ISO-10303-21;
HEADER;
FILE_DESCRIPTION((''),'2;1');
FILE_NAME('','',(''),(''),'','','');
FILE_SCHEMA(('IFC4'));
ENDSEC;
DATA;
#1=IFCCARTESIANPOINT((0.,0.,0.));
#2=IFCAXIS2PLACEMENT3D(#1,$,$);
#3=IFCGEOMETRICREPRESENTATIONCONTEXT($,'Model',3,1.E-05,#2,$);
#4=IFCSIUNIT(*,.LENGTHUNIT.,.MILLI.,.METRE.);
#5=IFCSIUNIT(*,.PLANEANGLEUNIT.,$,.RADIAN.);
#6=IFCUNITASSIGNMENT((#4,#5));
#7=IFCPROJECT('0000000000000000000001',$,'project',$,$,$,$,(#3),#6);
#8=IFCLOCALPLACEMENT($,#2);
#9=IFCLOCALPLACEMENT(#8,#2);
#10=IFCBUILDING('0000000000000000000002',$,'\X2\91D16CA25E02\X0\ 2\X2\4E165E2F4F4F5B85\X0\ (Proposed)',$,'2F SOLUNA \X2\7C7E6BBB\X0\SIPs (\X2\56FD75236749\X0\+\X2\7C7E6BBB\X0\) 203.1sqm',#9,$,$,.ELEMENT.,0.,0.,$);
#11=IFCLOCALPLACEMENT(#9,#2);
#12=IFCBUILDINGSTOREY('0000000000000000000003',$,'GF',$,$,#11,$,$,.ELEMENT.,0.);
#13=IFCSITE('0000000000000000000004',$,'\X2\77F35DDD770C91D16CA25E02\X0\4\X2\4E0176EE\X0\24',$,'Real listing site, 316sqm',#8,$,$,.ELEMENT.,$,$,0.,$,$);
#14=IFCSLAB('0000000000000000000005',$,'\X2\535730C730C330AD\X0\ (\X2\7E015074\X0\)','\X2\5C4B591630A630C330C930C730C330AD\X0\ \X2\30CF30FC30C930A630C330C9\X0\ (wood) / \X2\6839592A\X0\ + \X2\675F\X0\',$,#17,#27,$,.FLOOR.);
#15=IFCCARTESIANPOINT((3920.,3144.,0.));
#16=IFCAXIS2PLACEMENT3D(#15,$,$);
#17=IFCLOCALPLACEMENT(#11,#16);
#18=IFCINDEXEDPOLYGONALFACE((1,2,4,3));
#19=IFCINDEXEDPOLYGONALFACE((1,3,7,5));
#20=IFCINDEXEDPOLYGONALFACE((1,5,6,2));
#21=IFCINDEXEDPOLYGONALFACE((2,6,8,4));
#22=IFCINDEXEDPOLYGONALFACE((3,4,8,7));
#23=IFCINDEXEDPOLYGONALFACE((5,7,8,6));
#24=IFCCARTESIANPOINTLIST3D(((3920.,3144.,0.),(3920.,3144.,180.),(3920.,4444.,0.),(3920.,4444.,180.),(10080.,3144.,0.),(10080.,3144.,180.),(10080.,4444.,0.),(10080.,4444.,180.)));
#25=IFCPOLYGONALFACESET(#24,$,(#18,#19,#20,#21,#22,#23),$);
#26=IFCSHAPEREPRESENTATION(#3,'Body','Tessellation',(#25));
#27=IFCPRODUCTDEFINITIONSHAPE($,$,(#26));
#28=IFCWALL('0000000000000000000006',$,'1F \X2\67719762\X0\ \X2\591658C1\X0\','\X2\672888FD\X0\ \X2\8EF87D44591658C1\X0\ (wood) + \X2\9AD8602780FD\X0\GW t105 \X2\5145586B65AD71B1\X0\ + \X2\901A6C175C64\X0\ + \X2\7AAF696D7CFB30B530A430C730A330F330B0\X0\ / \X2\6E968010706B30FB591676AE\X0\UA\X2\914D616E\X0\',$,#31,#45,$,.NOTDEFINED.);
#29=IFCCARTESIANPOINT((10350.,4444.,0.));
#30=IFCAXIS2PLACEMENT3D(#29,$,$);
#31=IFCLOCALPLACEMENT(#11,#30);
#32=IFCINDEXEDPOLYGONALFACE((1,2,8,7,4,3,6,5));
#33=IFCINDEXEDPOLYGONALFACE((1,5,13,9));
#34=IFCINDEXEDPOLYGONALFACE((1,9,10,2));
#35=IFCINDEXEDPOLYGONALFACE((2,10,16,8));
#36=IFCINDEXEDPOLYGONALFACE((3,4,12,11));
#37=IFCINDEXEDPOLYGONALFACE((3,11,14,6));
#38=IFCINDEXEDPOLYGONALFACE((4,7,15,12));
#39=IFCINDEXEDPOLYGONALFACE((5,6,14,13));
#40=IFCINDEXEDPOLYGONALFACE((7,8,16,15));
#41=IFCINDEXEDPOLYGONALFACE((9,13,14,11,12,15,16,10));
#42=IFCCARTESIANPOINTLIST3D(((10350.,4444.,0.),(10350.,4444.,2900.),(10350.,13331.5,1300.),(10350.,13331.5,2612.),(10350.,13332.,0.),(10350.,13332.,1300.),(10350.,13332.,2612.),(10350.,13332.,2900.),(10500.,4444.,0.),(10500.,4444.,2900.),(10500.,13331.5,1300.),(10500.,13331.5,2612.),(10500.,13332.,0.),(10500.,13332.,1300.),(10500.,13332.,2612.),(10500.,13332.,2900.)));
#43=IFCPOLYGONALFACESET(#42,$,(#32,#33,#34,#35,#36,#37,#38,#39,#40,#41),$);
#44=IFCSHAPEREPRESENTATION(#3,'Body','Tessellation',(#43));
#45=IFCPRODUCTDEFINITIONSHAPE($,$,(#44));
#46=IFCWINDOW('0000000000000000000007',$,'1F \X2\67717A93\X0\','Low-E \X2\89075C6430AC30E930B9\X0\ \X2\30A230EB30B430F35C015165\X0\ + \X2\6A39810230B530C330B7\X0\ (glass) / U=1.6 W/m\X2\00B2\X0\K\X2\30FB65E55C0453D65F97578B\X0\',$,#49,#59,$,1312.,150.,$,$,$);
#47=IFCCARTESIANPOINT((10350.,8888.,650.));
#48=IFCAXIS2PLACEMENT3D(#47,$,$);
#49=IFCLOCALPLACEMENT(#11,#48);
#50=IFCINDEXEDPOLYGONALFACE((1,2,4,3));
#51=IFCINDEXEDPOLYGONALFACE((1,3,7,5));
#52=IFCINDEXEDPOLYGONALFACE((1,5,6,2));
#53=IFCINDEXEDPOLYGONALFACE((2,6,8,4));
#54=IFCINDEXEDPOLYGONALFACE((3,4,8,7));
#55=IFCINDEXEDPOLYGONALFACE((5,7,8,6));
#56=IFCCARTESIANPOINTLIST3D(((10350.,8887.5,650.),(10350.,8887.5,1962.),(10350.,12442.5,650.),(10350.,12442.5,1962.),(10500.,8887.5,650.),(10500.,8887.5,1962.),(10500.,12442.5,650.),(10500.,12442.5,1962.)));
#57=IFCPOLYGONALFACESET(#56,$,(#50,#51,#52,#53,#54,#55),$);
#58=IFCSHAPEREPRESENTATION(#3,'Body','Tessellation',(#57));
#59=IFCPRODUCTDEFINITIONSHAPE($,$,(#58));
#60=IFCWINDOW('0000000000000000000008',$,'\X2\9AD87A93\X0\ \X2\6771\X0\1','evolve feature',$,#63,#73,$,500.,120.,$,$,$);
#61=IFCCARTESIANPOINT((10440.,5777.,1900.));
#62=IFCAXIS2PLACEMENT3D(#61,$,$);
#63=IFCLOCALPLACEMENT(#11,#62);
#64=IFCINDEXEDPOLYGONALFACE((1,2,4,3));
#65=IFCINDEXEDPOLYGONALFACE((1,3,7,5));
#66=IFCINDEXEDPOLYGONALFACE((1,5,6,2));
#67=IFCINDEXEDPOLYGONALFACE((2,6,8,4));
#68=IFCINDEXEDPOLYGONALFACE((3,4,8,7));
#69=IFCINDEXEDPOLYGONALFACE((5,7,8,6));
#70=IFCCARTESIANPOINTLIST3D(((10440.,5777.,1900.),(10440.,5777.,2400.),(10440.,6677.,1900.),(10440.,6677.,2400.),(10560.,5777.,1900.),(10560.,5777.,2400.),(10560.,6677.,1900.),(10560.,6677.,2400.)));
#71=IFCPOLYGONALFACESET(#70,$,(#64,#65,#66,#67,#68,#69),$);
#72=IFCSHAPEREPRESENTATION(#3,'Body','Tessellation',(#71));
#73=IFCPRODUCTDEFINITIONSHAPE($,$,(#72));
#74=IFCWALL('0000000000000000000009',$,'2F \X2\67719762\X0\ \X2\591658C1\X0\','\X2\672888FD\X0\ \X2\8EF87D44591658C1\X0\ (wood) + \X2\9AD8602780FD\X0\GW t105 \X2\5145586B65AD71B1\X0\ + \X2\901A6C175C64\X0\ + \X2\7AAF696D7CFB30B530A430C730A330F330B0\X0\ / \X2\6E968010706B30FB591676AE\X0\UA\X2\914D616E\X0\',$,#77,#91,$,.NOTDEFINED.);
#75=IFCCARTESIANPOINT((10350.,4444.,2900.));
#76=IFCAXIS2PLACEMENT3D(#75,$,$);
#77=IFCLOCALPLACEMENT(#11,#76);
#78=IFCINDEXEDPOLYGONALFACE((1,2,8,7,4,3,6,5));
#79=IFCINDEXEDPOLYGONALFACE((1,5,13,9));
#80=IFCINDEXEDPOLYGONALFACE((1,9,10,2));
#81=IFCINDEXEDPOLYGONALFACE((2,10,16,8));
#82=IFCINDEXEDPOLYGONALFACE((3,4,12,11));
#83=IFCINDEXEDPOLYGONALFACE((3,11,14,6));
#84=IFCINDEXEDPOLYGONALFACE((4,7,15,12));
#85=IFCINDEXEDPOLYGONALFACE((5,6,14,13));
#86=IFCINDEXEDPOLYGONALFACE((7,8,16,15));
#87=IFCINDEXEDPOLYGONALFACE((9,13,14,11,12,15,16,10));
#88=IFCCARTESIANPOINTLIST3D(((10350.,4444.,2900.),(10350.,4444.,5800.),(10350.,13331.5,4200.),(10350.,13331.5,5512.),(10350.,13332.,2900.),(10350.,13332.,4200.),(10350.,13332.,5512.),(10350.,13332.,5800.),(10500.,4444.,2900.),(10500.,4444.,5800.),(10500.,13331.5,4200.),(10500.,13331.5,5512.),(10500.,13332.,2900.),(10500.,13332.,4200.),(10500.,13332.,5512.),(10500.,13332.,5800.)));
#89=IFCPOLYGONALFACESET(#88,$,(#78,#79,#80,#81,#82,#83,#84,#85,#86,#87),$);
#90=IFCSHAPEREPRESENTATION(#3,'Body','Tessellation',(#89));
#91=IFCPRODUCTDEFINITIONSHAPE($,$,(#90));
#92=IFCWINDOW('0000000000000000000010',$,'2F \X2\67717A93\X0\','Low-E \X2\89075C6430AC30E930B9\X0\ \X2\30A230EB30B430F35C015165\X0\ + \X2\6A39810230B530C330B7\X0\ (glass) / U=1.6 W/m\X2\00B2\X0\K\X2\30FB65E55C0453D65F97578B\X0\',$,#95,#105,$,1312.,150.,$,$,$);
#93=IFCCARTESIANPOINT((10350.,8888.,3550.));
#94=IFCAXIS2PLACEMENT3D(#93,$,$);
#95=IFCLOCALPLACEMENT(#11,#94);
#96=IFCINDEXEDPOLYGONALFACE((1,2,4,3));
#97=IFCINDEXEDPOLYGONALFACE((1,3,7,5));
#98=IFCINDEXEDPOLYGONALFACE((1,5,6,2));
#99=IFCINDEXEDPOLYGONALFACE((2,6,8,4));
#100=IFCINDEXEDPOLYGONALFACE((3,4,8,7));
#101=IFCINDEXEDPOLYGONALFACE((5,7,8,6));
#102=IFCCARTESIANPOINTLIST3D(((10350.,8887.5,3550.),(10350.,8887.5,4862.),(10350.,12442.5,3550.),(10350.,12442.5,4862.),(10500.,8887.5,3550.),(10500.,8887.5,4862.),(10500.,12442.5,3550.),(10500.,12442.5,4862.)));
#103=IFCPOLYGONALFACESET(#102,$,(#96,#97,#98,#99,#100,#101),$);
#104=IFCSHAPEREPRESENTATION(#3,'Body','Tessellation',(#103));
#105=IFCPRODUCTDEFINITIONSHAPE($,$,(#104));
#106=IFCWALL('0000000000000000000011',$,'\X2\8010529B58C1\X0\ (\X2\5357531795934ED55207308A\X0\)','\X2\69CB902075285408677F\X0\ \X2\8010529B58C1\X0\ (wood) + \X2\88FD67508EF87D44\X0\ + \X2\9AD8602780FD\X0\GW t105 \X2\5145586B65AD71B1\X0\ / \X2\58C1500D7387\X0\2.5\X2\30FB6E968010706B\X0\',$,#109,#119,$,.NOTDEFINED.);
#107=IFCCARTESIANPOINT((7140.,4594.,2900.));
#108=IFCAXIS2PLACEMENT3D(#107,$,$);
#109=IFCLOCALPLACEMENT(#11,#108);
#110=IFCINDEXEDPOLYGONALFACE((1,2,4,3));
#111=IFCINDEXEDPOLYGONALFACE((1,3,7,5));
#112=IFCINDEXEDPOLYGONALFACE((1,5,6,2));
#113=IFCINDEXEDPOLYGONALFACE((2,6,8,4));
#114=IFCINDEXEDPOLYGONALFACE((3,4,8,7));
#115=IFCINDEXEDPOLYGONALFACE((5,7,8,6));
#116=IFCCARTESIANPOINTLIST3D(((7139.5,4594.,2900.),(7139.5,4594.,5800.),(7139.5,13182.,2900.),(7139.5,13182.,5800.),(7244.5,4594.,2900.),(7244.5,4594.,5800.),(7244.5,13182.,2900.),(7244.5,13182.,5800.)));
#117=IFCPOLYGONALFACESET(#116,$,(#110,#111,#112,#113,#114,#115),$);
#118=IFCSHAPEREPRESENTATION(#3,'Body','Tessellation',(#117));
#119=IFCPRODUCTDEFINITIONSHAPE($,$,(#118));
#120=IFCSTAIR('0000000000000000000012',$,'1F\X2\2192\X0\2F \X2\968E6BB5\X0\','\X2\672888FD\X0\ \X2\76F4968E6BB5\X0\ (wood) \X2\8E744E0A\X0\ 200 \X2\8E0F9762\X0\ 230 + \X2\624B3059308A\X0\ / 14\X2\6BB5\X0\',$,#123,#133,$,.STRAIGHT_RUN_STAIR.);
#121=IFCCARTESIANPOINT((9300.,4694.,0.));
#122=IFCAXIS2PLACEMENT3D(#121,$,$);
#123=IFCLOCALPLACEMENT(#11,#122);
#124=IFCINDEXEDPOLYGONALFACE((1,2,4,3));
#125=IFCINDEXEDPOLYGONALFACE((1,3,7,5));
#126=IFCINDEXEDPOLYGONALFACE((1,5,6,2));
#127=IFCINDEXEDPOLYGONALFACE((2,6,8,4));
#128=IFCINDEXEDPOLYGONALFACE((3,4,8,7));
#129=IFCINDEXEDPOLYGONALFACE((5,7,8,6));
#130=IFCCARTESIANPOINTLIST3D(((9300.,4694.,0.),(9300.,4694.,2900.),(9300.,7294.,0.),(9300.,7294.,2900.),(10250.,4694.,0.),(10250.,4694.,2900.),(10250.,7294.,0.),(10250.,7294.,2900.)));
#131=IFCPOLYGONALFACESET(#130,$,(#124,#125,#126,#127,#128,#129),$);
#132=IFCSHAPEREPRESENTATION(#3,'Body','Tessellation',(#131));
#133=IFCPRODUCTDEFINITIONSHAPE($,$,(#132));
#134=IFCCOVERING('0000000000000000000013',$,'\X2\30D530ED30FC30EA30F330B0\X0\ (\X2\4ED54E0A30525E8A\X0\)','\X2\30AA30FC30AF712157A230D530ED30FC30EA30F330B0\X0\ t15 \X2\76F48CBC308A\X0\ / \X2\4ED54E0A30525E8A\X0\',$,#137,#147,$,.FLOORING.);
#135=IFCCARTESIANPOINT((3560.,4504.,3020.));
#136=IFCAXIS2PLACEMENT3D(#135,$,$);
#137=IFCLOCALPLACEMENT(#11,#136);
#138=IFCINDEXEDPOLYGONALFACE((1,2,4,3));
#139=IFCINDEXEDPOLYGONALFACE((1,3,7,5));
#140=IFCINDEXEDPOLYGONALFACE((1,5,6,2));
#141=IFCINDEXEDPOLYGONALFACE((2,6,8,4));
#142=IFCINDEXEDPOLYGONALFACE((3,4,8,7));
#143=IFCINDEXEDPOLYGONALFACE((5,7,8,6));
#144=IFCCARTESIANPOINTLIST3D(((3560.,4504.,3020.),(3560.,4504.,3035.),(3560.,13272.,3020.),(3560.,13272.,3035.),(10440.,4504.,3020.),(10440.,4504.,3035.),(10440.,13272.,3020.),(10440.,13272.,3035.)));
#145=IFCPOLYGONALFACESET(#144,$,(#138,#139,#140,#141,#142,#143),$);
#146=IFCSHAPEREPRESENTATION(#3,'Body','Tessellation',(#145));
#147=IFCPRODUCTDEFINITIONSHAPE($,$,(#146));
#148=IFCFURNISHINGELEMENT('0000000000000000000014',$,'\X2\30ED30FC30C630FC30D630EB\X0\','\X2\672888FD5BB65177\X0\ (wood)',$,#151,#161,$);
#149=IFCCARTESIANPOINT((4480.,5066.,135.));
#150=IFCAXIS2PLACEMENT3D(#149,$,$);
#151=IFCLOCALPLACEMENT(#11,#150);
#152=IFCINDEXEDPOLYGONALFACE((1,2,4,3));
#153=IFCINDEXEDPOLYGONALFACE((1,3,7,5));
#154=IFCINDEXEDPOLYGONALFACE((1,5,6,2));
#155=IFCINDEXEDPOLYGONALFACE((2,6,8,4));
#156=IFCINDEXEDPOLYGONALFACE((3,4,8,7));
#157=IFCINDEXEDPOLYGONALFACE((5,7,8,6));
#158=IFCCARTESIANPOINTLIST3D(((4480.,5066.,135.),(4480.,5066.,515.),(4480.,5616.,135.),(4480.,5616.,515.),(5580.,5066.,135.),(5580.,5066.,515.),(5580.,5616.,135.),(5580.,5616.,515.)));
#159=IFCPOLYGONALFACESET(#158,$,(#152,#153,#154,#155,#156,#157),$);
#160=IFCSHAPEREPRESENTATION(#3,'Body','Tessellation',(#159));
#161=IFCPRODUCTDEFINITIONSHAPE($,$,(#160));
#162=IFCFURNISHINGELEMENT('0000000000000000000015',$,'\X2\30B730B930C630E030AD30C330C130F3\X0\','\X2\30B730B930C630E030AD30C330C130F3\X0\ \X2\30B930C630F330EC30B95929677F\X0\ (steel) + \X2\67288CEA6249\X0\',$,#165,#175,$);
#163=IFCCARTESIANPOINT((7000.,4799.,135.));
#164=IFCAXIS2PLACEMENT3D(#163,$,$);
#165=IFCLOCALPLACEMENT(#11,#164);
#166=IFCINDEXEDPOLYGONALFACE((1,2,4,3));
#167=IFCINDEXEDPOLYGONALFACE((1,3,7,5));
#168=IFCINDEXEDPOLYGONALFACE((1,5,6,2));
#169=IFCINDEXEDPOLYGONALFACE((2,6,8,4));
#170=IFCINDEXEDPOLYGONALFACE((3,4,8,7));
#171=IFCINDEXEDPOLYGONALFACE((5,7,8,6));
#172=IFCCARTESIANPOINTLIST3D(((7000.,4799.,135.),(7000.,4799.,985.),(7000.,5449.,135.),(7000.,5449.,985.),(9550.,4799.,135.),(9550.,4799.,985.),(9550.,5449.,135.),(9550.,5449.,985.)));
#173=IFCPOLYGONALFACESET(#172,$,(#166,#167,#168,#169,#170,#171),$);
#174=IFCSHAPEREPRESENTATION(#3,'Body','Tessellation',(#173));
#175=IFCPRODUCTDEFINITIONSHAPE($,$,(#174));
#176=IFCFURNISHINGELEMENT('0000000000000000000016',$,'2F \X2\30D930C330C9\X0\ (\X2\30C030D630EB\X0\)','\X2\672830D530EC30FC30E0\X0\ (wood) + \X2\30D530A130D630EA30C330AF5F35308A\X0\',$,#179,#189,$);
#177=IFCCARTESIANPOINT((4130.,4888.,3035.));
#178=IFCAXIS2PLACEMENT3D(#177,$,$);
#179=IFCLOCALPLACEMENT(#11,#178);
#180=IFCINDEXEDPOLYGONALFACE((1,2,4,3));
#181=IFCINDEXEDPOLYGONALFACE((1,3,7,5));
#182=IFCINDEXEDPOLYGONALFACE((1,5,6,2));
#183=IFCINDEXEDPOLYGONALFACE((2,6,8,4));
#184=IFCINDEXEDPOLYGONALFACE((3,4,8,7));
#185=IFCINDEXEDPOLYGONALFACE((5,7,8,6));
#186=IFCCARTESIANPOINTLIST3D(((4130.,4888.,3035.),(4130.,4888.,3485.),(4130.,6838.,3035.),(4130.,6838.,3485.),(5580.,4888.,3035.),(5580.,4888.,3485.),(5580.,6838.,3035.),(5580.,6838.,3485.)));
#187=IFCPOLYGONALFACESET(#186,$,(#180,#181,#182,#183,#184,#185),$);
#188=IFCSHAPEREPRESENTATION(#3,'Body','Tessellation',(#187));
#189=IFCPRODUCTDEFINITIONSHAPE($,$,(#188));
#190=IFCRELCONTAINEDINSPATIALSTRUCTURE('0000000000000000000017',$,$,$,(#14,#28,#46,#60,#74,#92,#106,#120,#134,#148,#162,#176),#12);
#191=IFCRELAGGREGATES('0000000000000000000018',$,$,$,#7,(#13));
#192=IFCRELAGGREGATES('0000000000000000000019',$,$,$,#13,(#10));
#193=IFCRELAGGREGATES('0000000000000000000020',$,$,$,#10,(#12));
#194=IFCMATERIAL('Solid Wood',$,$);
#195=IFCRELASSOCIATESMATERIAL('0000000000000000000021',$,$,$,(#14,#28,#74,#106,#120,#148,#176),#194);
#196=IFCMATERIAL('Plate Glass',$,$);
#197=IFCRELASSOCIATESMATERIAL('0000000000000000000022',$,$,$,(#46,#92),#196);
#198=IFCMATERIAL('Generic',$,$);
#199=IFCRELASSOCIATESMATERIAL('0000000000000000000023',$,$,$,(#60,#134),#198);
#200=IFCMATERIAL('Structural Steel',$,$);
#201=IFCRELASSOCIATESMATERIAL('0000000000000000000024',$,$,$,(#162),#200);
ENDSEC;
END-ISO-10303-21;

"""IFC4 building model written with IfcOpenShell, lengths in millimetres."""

from ifc_helpers import new_model, si_unit, frame, frame_2d, origin, place, context, project, spatial, rectangle, extrude, material, element, fill, save


model = new_model("IFC4")

# Units and contexts
model_context = context("Model", 3, precision=1e-05, world=origin())
ifc_project = project(units=[si_unit("LENGTHUNIT", "METRE", prefix="MILLI"), si_unit("PLANEANGLEUNIT", "RADIAN")], contexts=[model_context])

# Site, building, storey
site_placement = place(None, origin())
site = spatial("IfcSite", under=ifc_project, at=site_placement, Name="石川県金沢市4丁目24", ObjectType="Real listing site, 316sqm", CompositionType="ELEMENT", RefElevation=0.0)
building_placement = place(site_placement, origin())
building = spatial("IfcBuilding", under=site, at=building_placement, Name="金沢市 2世帯住宅 (Proposed)", ObjectType="2F SOLUNA 籾殻SIPs (国産杉+籾殻) 203.1sqm", CompositionType="ELEMENT", ElevationOfRefHeight=0.0, ElevationOfTerrain=0.0)
storey_placement = place(building_placement, origin())
storey = spatial("IfcBuildingStorey", under=building, at=storey_placement, Name="GF", CompositionType="ELEMENT", Elevation=0.0)

# Slab
ifc_material_1 = material(Name="Solid Wood")
slab_placement = place(storey_placement, frame((3920.0, 3144.0, 0.0)))
element("IfcSlab", 1, at=slab_placement, inside=storey, material=ifc_material_1, Name="南デッキ (縁側)", Description="屋外ウッドデッキ ハードウッド (wood) / 根太 + 束", PredefinedType="FLOOR", context=model_context, shape_type="SweptSolid", body=[
    extrude(rectangle(XDim=6160.0, YDim=1300.0, at=frame_2d((3080.0, 650.0))), frame((3920.0, 3144.0, 0.0)), (0.0, 0.0, 1.0), 180.0),
])

# Wall, openings, windows
wall_1_placement = place(storey_placement, frame((10350.0, 4444.0, 0.0)))
wall_1 = element("IfcWall", 2, at=wall_1_placement, inside=storey, material=ifc_material_1, Name="1F 東面 外壁", Description="木製 軸組外壁 (wood) + 高性能GW t105 充填断熱 + 通気層 + 窯業系サイディング / 準耐火・外皮UA配慮", PredefinedType="NOTDEFINED", context=model_context, shape_type="SweptSolid", body=[
    extrude(rectangle(XDim=150.0, YDim=8888.0, at=frame_2d((75.0, 4444.0))), frame((10350.0, 4444.0, 0.0)), (0.0, 0.0, 1.0), 2900.0),
])
opening_1_placement = place(storey_placement, frame((10350.0, 8888.0, 650.0)))
opening_1 = element("IfcOpeningElement", 3, at=opening_1_placement, cuts=wall_1, PredefinedType="NOTDEFINED", context=model_context, shape_type="SweptSolid", body=[
    extrude(rectangle(XDim=150.0, YDim=3555.0, at=frame_2d((75.0, 1777.0))), frame((10350.0, 8888.0, 650.0)), (0.0, 0.0, 1.0), 1312.0),
])
opening_2_placement = place(storey_placement, frame((10440.0, 5777.0, 1900.0)))
opening_2 = element("IfcOpeningElement", 4, at=opening_2_placement, cuts=wall_1, PredefinedType="NOTDEFINED", context=model_context, shape_type="SweptSolid", body=[
    extrude(rectangle(XDim=120.0, YDim=900.0, at=frame_2d((60.0, 450.0))), frame((10440.0, 5777.0, 1900.0)), (0.0, 0.0, 1.0), 500.0),
])
ifc_material_2 = material(Name="Plate Glass")
window_1_placement = place(storey_placement, frame((10350.0, 8888.0, 650.0)))
window_1 = element("IfcWindow", 5, at=window_1_placement, inside=storey, material=ifc_material_2, Name="1F 東窓", Description="Low-E 複層ガラス アルゴン封入 + 樹脂サッシ (glass) / U=1.6 W/m²K・日射取得型", OverallHeight=1312.0, OverallWidth=150.0, context=model_context, shape_type="SweptSolid", body=[
    extrude(rectangle(XDim=150.0, YDim=3555.0, at=frame_2d((75.0, 1777.0))), frame((10350.0, 8888.0, 650.0)), (0.0, 0.0, 1.0), 1312.0),
])
fill(opening_1, window_1)
ifc_material_3 = material(Name="Generic")
window_2_placement = place(storey_placement, frame((10440.0, 5777.0, 1900.0)))
window_2 = element("IfcWindow", 6, at=window_2_placement, inside=storey, material=ifc_material_3, Name="高窓 東1", Description="evolve feature", OverallHeight=500.0, OverallWidth=120.0, context=model_context, shape_type="SweptSolid", body=[
    extrude(rectangle(XDim=120.0, YDim=900.0, at=frame_2d((60.0, 450.0))), frame((10440.0, 5777.0, 1900.0)), (0.0, 0.0, 1.0), 500.0),
])
fill(opening_2, window_2)

# Wall, opening, window
wall_2_placement = place(storey_placement, frame((10350.0, 4444.0, 2900.0)))
wall_2 = element("IfcWall", 7, at=wall_2_placement, inside=storey, material=ifc_material_1, Name="2F 東面 外壁", Description="木製 軸組外壁 (wood) + 高性能GW t105 充填断熱 + 通気層 + 窯業系サイディング / 準耐火・外皮UA配慮", PredefinedType="NOTDEFINED", context=model_context, shape_type="SweptSolid", body=[
    extrude(rectangle(XDim=150.0, YDim=8888.0, at=frame_2d((75.0, 4444.0))), frame((10350.0, 4444.0, 2900.0)), (0.0, 0.0, 1.0), 2900.0),
])
opening_3_placement = place(storey_placement, frame((10350.0, 8888.0, 3550.0)))
opening_3 = element("IfcOpeningElement", 8, at=opening_3_placement, cuts=wall_2, PredefinedType="NOTDEFINED", context=model_context, shape_type="SweptSolid", body=[
    extrude(rectangle(XDim=150.0, YDim=3555.0, at=frame_2d((75.0, 1777.0))), frame((10350.0, 8888.0, 3550.0)), (0.0, 0.0, 1.0), 1312.0),
])
window_3_placement = place(storey_placement, frame((10350.0, 8888.0, 3550.0)))
window_3 = element("IfcWindow", 9, at=window_3_placement, inside=storey, material=ifc_material_2, Name="2F 東窓", Description="Low-E 複層ガラス アルゴン封入 + 樹脂サッシ (glass) / U=1.6 W/m²K・日射取得型", OverallHeight=1312.0, OverallWidth=150.0, context=model_context, shape_type="SweptSolid", body=[
    extrude(rectangle(XDim=150.0, YDim=3555.0, at=frame_2d((75.0, 1777.0))), frame((10350.0, 8888.0, 3550.0)), (0.0, 0.0, 1.0), 1312.0),
])
fill(opening_3, window_3)

# Wall
wall_3_placement = place(storey_placement, frame((7140.0, 4594.0, 2900.0)))
element("IfcWall", 10, at=wall_3_placement, inside=storey, material=ifc_material_1, Name="耐力壁 (南北間仕切り)", Description="構造用合板 耐力壁 (wood) + 製材軸組 + 高性能GW t105 充填断熱 / 壁倍率2.5・準耐火", PredefinedType="NOTDEFINED", context=model_context, shape_type="SweptSolid", body=[
    extrude(rectangle(XDim=105.0, YDim=8588.0, at=frame_2d((52.0, 4294.0))), frame((7140.0, 4594.0, 2900.0)), (0.0, 0.0, 1.0), 2900.0),
])

# Stair
stair_placement = place(storey_placement, frame((9300.0, 4694.0, 0.0)))
element("IfcStair", 11, at=stair_placement, inside=storey, material=ifc_material_1, Name="1F→2F 階段", Description="木製 直階段 (wood) 蹴上 200 踏面 230 + 手すり / 14段", PredefinedType="STRAIGHT_RUN_STAIR", context=model_context, shape_type="SweptSolid", body=[
    extrude(rectangle(XDim=950.0, YDim=2600.0, at=frame_2d((475.0, 1300.0))), frame((9300.0, 4694.0, 0.0)), (0.0, 0.0, 1.0), 2900.0),
])

# Covering
covering_placement = place(storey_placement, frame((3560.0, 4504.0, 3020.0)))
element("IfcCovering", 12, at=covering_placement, inside=storey, material=ifc_material_3, Name="フローリング (仕上げ床)", Description="オーク無垢フローリング t15 直貼り / 仕上げ床", PredefinedType="FLOORING", context=model_context, shape_type="SweptSolid", body=[
    extrude(rectangle(XDim=6880.0, YDim=8768.0, at=frame_2d((3440.0, 4384.0))), frame((3560.0, 4504.0, 3020.0)), (0.0, 0.0, 1.0), 15.0),
])

# Furnishing elements
furnishing_1_placement = place(storey_placement, frame((4480.0, 5066.0, 135.0)))
element("IfcFurnishingElement", 13, at=furnishing_1_placement, inside=storey, material=ifc_material_1, Name="ローテーブル", Description="木製家具 (wood)", context=model_context, shape_type="SweptSolid", body=[
    extrude(rectangle(XDim=1100.0, YDim=550.0, at=frame_2d((550.0, 275.0))), frame((4480.0, 5066.0, 135.0)), (0.0, 0.0, 1.0), 380.0),
])
ifc_material_4 = material(Name="Structural Steel")
furnishing_2_placement = place(storey_placement, frame((7000.0, 4799.0, 135.0)))
element("IfcFurnishingElement", 14, at=furnishing_2_placement, inside=storey, material=ifc_material_4, Name="システムキッチン", Description="システムキッチン ステンレス天板 (steel) + 木質扉", context=model_context, shape_type="SweptSolid", body=[
    extrude(rectangle(XDim=2550.0, YDim=650.0, at=frame_2d((1275.0, 325.0))), frame((7000.0, 4799.0, 135.0)), (0.0, 0.0, 1.0), 850.0),
])
furnishing_3_placement = place(storey_placement, frame((4130.0, 4888.0, 3035.0)))
element("IfcFurnishingElement", 15, at=furnishing_3_placement, inside=storey, material=ifc_material_1, Name="2F ベッド (ダブル)", Description="木フレーム (wood) + ファブリック張り", context=model_context, shape_type="SweptSolid", body=[
    extrude(rectangle(XDim=1450.0, YDim=1950.0, at=frame_2d((725.0, 975.0))), frame((4130.0, 4888.0, 3035.0)), (0.0, 0.0, 1.0), 450.0),
])

save(model, "model.ifc")
